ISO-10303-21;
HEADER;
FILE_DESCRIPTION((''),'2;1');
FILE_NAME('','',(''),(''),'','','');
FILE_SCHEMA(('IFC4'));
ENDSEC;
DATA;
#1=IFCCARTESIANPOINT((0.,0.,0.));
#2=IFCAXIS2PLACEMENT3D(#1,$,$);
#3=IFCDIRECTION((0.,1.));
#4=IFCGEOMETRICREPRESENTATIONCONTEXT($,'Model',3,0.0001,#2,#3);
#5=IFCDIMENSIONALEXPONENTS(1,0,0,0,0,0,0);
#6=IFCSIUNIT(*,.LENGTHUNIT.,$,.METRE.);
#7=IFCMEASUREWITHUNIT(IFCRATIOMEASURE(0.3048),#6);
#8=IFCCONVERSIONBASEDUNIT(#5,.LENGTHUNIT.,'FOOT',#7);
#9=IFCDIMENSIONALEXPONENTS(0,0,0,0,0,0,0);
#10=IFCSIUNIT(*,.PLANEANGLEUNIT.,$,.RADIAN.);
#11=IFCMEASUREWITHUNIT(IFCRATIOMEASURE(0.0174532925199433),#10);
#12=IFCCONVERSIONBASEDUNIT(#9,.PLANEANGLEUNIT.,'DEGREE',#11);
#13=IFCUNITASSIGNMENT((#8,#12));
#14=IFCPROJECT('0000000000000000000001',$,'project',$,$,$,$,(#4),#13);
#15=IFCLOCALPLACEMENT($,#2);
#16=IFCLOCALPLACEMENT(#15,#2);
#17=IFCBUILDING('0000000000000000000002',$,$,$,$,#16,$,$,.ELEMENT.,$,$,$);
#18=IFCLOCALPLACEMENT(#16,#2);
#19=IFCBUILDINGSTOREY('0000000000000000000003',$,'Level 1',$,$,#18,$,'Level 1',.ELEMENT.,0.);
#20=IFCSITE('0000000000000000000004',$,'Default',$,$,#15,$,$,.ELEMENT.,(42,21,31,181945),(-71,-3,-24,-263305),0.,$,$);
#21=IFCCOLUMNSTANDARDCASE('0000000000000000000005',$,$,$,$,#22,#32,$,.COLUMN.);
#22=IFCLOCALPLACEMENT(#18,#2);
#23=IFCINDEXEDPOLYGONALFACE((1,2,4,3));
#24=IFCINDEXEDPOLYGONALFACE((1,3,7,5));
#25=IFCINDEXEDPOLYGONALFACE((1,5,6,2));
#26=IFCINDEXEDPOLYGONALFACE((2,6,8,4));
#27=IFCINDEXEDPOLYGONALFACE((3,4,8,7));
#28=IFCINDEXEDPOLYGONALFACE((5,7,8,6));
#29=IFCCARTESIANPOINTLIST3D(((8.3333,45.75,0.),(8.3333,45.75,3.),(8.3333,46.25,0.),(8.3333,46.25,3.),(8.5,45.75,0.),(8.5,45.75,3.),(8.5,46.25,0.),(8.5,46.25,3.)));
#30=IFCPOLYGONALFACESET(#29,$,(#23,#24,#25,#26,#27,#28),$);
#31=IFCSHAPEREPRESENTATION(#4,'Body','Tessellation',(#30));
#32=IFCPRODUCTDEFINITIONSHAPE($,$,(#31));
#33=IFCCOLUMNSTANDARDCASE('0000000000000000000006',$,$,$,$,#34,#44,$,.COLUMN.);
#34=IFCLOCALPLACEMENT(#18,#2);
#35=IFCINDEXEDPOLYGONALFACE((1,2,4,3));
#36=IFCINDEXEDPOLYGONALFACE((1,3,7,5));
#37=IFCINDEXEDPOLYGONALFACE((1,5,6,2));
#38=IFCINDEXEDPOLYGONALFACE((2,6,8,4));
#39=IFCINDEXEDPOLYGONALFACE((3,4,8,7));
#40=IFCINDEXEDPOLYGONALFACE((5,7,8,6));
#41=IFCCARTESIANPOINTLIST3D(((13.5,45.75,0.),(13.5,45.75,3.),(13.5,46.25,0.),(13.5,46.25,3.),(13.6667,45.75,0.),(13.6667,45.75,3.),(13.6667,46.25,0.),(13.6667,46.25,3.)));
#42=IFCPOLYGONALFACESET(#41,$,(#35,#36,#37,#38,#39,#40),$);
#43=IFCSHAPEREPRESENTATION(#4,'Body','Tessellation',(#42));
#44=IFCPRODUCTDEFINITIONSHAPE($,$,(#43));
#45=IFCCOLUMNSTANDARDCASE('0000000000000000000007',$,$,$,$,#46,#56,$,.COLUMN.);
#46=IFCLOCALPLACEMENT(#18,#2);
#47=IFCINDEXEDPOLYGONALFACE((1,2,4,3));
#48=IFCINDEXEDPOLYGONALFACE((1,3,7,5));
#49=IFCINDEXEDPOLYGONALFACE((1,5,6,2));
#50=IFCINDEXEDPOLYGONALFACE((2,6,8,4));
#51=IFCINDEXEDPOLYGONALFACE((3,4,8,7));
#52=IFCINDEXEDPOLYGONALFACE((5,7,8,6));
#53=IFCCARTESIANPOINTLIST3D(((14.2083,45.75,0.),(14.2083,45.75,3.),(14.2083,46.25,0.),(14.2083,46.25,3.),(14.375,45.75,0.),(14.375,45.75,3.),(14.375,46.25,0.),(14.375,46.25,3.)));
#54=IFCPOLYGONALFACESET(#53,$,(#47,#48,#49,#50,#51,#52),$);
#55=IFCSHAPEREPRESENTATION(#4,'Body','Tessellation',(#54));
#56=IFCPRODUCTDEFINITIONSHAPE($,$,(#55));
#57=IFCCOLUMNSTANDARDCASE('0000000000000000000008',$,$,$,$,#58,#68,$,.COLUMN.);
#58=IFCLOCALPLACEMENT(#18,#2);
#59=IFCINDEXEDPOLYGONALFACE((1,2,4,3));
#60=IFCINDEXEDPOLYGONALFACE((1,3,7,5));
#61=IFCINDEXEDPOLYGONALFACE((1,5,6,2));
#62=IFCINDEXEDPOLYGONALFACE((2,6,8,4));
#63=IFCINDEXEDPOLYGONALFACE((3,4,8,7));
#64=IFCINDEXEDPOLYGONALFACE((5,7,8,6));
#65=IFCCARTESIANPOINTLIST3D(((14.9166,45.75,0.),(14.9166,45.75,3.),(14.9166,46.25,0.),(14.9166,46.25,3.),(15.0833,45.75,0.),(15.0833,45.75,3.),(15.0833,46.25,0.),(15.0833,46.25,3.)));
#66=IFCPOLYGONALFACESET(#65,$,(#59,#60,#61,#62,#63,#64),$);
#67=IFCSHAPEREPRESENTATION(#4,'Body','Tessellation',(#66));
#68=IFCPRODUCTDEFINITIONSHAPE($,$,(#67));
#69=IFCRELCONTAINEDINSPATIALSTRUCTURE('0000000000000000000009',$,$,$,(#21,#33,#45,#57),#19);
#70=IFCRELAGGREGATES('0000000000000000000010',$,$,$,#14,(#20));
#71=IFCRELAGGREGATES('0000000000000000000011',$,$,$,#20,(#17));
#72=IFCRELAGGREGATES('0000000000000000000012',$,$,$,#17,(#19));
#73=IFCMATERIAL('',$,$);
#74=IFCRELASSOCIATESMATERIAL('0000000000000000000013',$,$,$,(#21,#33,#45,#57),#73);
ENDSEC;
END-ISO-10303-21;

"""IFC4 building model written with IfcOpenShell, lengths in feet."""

from ifc_helpers import new_model, entity, si_unit, converted_unit, direction, frame, origin, place, context, project, spatial, rectangle, extrude, material, element, save


model = new_model("IFC4")

# Units and contexts
model_context = context("Model", 3, precision=0.0001, world=origin(), true_north=direction((0.0, 1.0)))
ifc_project = project(units=[converted_unit("LENGTHUNIT", "FOOT", entity("IfcRatioMeasure", 0.3048), si_unit("LENGTHUNIT", "METRE"), dimensions=[1, 0, 0, 0, 0, 0, 0]), converted_unit("PLANEANGLEUNIT", "DEGREE", entity("IfcRatioMeasure", 0.0174532925199433), si_unit("PLANEANGLEUNIT", "RADIAN"), dimensions=[0, 0, 0, 0, 0, 0, 0])], contexts=[model_context])

# Site, building, storey
site_placement = place(None, origin())
site = spatial("IfcSite", under=ifc_project, at=site_placement, Name="Default", CompositionType="ELEMENT", RefLatitude=(42, 21, 31, 181945), RefLongitude=(-71, -3, -24, -263305), RefElevation=0.0)
building_placement = place(site_placement, origin())
building = spatial("IfcBuilding", under=site, at=building_placement, CompositionType="ELEMENT")
storey_placement = place(building_placement, origin())
storey = spatial("IfcBuildingStorey", under=building, at=storey_placement, Name="Level 1", LongName="Level 1", CompositionType="ELEMENT", Elevation=0.0)

# Columns
placement = place(storey_placement, frame((-0.25, 46.0, 0.0)))
ifc_material_1 = material(Name="")
for number, where, z_axis, x_axis in (
    (1, (8.6666, 0.0, 0.0), (0.0, 0.0, 1.0), (1.0, 0.0, 0.0)),
    (2, (13.8333, 0.0, 0.0), (0.0, 0.0, 1.0), (1.0, 0.0, 0.0)),
    (3, (14.5417, 0.0, 0.0), (0.0, 0.0, 1.0), (1.0, 0.0, 0.0)),
    (4, (15.25, 0.0, 0.0), (0.0, 0.0, 1.0), (1.0, 0.0, 0.0)),
):
    element("IfcColumnStandardCase", number, at=place(placement, frame(where, z_axis=z_axis, x_axis=x_axis)), inside=storey, material=ifc_material_1, PredefinedType="COLUMN", context=model_context, shape_type="SweptSolid", body=[
        extrude(rectangle(XDim=0.1667, YDim=0.5), origin(), (0.0, 0.0, 1.0), 3.0),
    ])

save(model, "model.ifc")
